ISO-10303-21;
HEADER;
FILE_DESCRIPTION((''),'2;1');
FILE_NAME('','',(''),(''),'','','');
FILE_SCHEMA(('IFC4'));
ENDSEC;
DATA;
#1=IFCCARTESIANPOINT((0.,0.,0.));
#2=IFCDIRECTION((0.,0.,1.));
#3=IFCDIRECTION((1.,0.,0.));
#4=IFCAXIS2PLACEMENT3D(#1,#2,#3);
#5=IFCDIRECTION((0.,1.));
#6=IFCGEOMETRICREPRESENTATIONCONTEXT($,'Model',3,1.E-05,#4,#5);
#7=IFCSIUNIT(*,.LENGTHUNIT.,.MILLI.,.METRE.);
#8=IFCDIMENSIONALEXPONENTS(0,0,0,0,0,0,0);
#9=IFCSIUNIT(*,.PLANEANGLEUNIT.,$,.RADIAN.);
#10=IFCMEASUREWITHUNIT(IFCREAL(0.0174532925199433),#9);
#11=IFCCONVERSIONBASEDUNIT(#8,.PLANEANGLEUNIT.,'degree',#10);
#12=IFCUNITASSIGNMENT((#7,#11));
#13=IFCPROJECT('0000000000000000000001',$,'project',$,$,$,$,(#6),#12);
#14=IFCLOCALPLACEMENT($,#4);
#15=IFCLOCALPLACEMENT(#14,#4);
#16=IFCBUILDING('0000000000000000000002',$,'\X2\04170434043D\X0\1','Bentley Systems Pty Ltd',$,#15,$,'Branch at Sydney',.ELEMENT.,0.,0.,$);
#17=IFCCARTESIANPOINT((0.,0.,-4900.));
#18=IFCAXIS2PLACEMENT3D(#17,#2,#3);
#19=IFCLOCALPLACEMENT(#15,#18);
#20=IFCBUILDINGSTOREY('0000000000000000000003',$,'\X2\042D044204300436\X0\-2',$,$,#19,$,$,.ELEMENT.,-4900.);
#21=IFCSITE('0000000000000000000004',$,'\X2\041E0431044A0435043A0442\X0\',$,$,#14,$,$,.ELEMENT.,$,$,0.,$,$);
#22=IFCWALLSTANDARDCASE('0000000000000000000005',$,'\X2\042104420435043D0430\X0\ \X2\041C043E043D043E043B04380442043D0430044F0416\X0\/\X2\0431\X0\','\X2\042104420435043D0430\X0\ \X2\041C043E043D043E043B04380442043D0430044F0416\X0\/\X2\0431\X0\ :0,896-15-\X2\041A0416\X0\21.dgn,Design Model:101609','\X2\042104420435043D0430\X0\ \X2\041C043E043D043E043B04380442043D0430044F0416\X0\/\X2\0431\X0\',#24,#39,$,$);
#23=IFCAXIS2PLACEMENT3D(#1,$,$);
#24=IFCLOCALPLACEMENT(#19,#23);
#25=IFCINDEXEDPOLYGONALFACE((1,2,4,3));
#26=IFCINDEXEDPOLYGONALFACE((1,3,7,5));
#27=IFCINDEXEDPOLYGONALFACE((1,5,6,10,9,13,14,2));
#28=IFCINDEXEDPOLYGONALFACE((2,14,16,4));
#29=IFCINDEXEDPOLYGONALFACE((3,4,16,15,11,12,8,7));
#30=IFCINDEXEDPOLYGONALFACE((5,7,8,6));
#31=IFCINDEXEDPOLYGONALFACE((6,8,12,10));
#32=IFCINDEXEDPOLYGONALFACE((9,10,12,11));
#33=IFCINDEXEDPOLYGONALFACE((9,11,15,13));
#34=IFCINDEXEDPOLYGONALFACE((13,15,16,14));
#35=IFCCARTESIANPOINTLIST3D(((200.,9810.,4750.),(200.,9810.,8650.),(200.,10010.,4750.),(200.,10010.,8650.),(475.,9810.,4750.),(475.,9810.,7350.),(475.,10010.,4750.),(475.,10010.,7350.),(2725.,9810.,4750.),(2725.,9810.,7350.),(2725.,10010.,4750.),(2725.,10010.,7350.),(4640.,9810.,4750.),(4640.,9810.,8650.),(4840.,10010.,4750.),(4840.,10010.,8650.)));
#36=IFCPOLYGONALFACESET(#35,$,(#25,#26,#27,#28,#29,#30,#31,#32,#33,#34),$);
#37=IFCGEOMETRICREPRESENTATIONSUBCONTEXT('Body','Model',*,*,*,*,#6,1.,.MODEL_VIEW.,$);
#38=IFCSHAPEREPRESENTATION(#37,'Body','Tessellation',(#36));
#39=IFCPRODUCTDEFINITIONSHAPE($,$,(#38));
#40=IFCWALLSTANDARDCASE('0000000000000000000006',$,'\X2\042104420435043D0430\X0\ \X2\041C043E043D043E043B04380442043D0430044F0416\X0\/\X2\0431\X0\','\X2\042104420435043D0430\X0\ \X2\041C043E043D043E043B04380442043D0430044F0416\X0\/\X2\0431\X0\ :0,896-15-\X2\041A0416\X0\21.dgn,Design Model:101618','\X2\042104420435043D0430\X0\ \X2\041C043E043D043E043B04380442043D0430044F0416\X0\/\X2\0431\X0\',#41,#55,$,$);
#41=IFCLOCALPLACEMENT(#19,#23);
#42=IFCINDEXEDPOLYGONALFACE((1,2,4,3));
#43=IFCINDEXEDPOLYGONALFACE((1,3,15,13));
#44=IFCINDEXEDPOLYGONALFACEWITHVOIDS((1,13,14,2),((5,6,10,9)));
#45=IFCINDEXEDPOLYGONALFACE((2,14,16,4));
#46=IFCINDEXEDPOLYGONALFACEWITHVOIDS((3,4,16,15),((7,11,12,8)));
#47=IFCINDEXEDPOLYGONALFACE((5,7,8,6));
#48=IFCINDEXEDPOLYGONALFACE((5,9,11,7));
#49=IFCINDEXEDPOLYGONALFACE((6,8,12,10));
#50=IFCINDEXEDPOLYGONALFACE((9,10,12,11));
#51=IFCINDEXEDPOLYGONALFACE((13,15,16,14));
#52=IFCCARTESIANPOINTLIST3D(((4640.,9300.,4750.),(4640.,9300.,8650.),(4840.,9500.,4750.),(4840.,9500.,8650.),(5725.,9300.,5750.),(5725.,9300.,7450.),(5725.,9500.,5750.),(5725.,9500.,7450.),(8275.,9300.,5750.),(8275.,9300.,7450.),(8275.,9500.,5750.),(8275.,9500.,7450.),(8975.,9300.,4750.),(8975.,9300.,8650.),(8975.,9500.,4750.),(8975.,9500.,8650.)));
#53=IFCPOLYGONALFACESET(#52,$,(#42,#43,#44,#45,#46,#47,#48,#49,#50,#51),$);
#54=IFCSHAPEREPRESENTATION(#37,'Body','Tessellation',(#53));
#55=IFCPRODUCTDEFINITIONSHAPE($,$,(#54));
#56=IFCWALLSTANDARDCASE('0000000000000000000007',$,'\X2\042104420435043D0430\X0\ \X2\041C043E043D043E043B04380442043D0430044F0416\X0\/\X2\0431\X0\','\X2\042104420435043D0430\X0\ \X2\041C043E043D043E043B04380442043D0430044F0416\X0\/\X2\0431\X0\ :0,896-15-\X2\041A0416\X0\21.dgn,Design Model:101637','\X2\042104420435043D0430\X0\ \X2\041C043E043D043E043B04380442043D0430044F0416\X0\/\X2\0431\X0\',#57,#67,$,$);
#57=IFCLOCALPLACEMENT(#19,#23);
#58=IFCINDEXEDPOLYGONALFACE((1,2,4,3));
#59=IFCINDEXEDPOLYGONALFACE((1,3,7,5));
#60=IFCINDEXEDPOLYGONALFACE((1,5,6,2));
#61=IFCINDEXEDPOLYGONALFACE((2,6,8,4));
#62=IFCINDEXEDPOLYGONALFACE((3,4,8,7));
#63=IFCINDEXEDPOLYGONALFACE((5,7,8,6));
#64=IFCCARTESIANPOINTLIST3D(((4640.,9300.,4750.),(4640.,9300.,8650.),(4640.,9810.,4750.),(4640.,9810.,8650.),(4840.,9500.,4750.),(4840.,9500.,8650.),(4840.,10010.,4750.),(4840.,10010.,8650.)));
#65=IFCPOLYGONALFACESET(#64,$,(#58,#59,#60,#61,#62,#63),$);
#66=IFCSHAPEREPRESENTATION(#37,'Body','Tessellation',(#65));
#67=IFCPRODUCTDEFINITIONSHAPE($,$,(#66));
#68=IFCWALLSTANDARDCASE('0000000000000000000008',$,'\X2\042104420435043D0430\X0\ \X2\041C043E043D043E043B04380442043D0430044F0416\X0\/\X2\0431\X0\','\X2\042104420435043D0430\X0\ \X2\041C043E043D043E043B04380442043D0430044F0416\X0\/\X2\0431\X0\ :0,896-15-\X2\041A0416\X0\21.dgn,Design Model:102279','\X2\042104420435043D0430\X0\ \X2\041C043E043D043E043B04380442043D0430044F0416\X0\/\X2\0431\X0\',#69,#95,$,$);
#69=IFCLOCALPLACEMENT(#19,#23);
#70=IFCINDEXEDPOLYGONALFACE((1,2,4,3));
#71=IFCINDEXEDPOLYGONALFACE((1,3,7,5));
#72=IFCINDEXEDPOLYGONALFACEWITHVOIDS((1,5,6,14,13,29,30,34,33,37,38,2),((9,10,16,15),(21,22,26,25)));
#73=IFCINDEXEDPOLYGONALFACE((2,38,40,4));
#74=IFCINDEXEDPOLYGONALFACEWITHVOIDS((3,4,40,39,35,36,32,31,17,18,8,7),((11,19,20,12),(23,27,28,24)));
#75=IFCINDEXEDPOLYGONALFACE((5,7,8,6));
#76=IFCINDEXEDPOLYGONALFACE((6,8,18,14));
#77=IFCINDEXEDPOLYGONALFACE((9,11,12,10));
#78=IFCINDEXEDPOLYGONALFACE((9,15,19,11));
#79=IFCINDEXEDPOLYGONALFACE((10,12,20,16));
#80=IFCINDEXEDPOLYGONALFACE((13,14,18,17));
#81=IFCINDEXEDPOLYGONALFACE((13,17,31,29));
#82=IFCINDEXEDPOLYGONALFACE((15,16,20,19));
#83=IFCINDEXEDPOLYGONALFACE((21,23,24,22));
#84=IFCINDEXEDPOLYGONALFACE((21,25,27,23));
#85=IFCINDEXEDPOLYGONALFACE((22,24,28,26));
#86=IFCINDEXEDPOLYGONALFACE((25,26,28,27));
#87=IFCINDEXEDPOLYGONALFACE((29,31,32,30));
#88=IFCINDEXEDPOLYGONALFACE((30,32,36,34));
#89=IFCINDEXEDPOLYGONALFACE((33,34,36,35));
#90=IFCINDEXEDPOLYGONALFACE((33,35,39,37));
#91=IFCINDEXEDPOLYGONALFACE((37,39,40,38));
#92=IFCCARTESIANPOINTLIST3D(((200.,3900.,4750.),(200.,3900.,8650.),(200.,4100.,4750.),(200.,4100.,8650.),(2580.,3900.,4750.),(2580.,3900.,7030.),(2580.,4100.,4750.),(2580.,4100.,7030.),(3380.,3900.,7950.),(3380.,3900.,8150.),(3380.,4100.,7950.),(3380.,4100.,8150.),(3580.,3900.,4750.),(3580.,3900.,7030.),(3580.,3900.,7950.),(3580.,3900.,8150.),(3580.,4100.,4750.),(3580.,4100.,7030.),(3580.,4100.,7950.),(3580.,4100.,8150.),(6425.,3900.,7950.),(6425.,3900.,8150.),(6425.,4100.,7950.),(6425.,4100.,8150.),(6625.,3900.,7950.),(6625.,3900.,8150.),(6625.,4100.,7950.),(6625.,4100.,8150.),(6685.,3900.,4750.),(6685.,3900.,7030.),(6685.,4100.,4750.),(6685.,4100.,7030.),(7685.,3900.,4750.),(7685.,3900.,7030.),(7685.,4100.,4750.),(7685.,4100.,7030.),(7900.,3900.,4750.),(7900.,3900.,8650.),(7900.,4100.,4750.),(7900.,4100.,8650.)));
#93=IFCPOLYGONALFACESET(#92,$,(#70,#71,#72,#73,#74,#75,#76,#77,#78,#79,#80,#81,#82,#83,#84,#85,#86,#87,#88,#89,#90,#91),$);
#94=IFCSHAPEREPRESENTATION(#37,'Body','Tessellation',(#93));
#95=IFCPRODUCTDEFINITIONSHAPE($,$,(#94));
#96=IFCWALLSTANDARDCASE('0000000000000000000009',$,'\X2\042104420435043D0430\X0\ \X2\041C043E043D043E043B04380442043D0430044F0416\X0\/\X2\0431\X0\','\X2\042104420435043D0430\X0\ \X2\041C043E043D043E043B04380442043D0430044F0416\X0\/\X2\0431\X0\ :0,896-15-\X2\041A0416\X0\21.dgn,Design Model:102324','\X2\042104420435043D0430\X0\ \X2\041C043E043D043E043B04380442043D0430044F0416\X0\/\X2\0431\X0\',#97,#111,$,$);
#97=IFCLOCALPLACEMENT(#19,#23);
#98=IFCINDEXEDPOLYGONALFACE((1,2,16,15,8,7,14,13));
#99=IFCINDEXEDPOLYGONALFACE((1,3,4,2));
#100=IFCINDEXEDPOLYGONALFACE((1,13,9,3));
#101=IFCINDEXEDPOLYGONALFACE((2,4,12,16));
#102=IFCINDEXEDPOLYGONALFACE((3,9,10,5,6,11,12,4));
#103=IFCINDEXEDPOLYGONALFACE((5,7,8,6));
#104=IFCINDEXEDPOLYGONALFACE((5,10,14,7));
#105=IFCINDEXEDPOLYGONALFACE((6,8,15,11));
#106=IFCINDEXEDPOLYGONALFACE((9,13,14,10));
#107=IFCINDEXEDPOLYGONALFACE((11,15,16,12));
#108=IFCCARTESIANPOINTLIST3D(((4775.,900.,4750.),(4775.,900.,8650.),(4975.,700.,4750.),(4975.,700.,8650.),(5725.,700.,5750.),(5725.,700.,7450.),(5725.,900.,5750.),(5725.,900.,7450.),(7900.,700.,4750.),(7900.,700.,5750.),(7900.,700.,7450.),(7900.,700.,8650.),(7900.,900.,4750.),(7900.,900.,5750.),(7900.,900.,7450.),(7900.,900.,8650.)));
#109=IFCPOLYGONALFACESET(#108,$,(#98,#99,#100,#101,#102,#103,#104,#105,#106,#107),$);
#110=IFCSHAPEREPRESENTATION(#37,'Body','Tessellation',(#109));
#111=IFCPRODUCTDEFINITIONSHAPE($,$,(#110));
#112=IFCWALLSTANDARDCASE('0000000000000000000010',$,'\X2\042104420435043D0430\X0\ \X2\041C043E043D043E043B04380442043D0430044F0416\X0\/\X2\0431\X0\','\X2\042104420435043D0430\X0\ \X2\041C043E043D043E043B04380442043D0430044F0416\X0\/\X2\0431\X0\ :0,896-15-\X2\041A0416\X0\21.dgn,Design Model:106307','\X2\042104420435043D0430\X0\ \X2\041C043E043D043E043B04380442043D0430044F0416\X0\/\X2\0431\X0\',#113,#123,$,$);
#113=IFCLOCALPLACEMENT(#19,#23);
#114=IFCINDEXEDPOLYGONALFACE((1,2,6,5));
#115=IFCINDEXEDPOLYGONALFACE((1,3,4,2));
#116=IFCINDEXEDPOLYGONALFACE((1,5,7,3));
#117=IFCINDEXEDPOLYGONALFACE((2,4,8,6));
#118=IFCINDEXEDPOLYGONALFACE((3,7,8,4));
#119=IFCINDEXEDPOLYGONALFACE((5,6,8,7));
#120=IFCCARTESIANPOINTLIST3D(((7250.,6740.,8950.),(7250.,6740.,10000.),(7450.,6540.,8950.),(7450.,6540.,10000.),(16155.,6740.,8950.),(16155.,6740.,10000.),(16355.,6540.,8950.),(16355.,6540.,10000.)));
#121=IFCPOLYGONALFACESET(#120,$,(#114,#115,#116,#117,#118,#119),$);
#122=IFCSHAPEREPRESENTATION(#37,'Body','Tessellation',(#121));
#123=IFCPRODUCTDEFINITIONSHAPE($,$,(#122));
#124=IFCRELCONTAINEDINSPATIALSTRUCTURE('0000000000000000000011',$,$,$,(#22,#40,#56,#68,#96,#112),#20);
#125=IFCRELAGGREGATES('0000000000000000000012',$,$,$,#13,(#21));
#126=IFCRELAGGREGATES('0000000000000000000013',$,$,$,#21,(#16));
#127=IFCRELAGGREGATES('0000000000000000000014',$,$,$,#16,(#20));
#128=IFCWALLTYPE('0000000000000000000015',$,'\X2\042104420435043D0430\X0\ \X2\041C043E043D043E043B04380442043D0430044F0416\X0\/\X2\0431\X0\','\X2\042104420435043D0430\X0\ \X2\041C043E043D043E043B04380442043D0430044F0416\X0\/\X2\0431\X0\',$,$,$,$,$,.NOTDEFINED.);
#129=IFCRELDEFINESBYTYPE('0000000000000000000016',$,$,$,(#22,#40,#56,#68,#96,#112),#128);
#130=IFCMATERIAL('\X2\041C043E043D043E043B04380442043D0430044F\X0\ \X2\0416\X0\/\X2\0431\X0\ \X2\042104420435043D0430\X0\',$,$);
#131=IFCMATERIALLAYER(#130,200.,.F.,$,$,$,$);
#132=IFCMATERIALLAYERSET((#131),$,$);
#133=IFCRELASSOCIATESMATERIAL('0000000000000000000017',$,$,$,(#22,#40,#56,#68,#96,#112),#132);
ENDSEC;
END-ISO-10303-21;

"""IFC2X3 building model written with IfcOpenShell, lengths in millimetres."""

from ifc_helpers import new_model, entity, si_unit, converted_unit, direction, frame, frame_2d, origin_with_axes, place, context, subcontext, project, spatial, polyline, rectangle, outline, extrude, material, layer, layer_set, layer_usage, type_object, element, save


model = new_model("IFC2X3")

# Units and contexts
model_context = context("Model", 3, precision=1e-05, world=origin_with_axes(), true_north=direction((0.0, 1.0)))
body_context = subcontext(model_context, "Body", "Model", "MODEL_VIEW", scale=1.0)
ifc_project = project(units=[si_unit("LENGTHUNIT", "METRE", prefix="MILLI"), converted_unit("PLANEANGLEUNIT", "degree", entity("IfcReal", 0.0174532925199433), si_unit("PLANEANGLEUNIT", "RADIAN"), dimensions=[0, 0, 0, 0, 0, 0, 0])], contexts=[model_context])

# Site, building, storey
site_placement = place(None, origin_with_axes())
site = spatial("IfcSite", under=ifc_project, at=site_placement, Name="Объект", CompositionType="ELEMENT", RefElevation=0.0)
building_placement = place(site_placement, origin_with_axes())
building = spatial("IfcBuilding", under=site, at=building_placement, Name="Здн1", Description="Bentley Systems Pty Ltd", LongName="Branch at Sydney", CompositionType="ELEMENT", ElevationOfRefHeight=0.0, ElevationOfTerrain=0.0)
storey_placement = place(building_placement, frame((0.0, 0.0, -4900.0), z_axis=(0.0, 0.0, 1.0), x_axis=(1.0, 0.0, 0.0)))
storey = spatial("IfcBuildingStorey", under=building, at=storey_placement, Name="Этаж-2", CompositionType="ELEMENT", Elevation=-4900.0)

# Shared definitions
ifc_material = material(Name="Монолитная Ж/б Стена")
wall_type = type_object("IfcWallType", Name="Стена МонолитнаяЖ/б", Description="Стена МонолитнаяЖ/б", PredefinedType="NOTDEFINED")

# Shared definitions
ifc_layer_1 = layer(ifc_material, 200.0, ventilated=False)
ifc_layer_set_1 = layer_set([ifc_layer_1])
ifc_layer_usage_1 = layer_usage(ifc_layer_set_1, "AXIS2", "POSITIVE", 0.0)

# Walls, openings
wall_1_placement = place(storey_placement, frame((200.0, 10010.0, 4750.0), z_axis=(0.0, 0.0, 1.0), x_axis=(1.0, 0.0, 0.0)))
wall_1 = element("IfcWallStandardCase", 1, at=wall_1_placement, inside=storey, type_object=wall_type, material=ifc_layer_usage_1, Name="Стена МонолитнаяЖ/б", Description="Стена МонолитнаяЖ/б :0,896-15-КЖ21.dgn,Design Model:101609", ObjectType="Стена МонолитнаяЖ/б", context=body_context, shape_type="SweptSolid", body=[
    extrude(outline(polyline([(4640.0, 0.0), (0.0, 0.0), (0.0, -200.0), (4440.0, -200.0), (4640.0, 0.0)])), origin_with_axes(), (0.0, 0.0, 1.0), 3900.0),
])
opening_1_placement = place(wall_1_placement, frame((275.0, -200.0, 0.0), z_axis=(0.0, 0.0, 1.0), x_axis=(1.0, 0.0, 0.0)))
element("IfcOpeningElement", 2, at=opening_1_placement, cuts=wall_1, ObjectType="Opening", context=body_context, shape_type="SweptSolid", body=[
    extrude(rectangle(XDim=2600.0, YDim=2250.0, at=frame_2d((-1125.0, 1300.0), x_axis=(0.0, -1.0))), frame((0.0, 0.0, 0.0), z_axis=(0.0, 1.0, 0.0), x_axis=(-1.0, 0.0, 0.0)), (0.0, 0.0, 1.0), 200.0),
])
wall_2_placement = place(storey_placement, frame((4640.0, 9300.0, 4750.0), z_axis=(0.0, 0.0, 1.0), x_axis=(1.0, 0.0, 0.0)))
wall_2 = element("IfcWallStandardCase", 3, at=wall_2_placement, inside=storey, type_object=wall_type, material=ifc_layer_usage_1, Name="Стена МонолитнаяЖ/б", Description="Стена МонолитнаяЖ/б :0,896-15-КЖ21.dgn,Design Model:101618", ObjectType="Стена МонолитнаяЖ/б", context=body_context, shape_type="SweptSolid", body=[
    extrude(outline(polyline([(200.0, 200.0), (0.0, 0.0), (4335.0, 0.0), (4335.0, 200.0), (200.0, 200.0)])), origin_with_axes(), (0.0, 0.0, 1.0), 3900.0),
])
opening_2_placement = place(wall_2_placement, frame((1085.0, 0.0, 1000.0), z_axis=(0.0, 0.0, 1.0), x_axis=(1.0, 0.0, 0.0)))
element("IfcOpeningElement", 4, at=opening_2_placement, cuts=wall_2, ObjectType="Opening", context=body_context, shape_type="SweptSolid", body=[
    extrude(rectangle(XDim=1700.0, YDim=2550.0, at=frame_2d((-1275.0, 850.0), x_axis=(0.0, -1.0))), frame((0.0, 0.0, 0.0), z_axis=(0.0, 1.0, 0.0), x_axis=(-1.0, 0.0, 0.0)), (0.0, 0.0, 1.0), 200.0),
])

# Wall
wall_3_placement = place(storey_placement, frame((4840.0, 10010.0, 4750.0), z_axis=(0.0, 0.0, 1.0), x_axis=(0.0, -1.0, 0.0)))
element("IfcWallStandardCase", 5, at=wall_3_placement, inside=storey, type_object=wall_type, material=ifc_layer_usage_1, Name="Стена МонолитнаяЖ/б", Description="Стена МонолитнаяЖ/б :0,896-15-КЖ21.dgn,Design Model:101637", ObjectType="Стена МонолитнаяЖ/б", context=body_context, shape_type="SweptSolid", body=[
    extrude(outline(polyline([(510.0, 0.0), (0.0, 0.0), (200.0, -200.0), (710.0, -200.0), (510.0, 0.0)])), origin_with_axes(), (0.0, 0.0, 1.0), 3900.0),
])

# Wall, openings
wall_4_placement = place(storey_placement, frame((200.0, 3900.0, 4750.0), z_axis=(0.0, 0.0, 1.0), x_axis=(1.0, 0.0, 0.0)))
wall_4 = element("IfcWallStandardCase", 6, at=wall_4_placement, inside=storey, type_object=wall_type, material=ifc_layer_usage_1, Name="Стена МонолитнаяЖ/б", Description="Стена МонолитнаяЖ/б :0,896-15-КЖ21.dgn,Design Model:102279", ObjectType="Стена МонолитнаяЖ/б", context=body_context, shape_type="SweptSolid", body=[
    extrude(rectangle(XDim=7700.0, YDim=200.0, at=frame_2d((3850.0, 100.0), x_axis=(1.0, 0.0))), origin_with_axes(), (0.0, 0.0, 1.0), 3900.0),
])
opening_3_placement = place(wall_4_placement, frame((2380.0, 0.0, 0.0), z_axis=(0.0, 0.0, 1.0), x_axis=(1.0, 0.0, 0.0)))
element("IfcOpeningElement", 7, at=opening_3_placement, cuts=wall_4, ObjectType="Opening", context=body_context, shape_type="SweptSolid", body=[
    extrude(rectangle(XDim=2280.0, YDim=1000.0, at=frame_2d((-500.0, 1140.0), x_axis=(0.0, -1.0))), frame((0.0, 0.0, 0.0), z_axis=(0.0, 1.0, 0.0), x_axis=(-1.0, 0.0, 0.0)), (0.0, 0.0, 1.0), 200.0),
])
opening_4_placement = place(wall_4_placement, frame((6485.0, 0.0, 0.0), z_axis=(0.0, 0.0, 1.0), x_axis=(1.0, 0.0, 0.0)))
element("IfcOpeningElement", 8, at=opening_4_placement, cuts=wall_4, ObjectType="Opening", context=body_context, shape_type="SweptSolid", body=[
    extrude(rectangle(XDim=2280.0, YDim=1000.0, at=frame_2d((-500.0, 1140.0), x_axis=(0.0, -1.0))), frame((0.0, 0.0, 0.0), z_axis=(0.0, 1.0, 0.0), x_axis=(-1.0, 0.0, 0.0)), (0.0, 0.0, 1.0), 200.0),
])
opening_5_placement = place(wall_4_placement, frame((3180.0, 0.0, 3200.0), z_axis=(0.0, 0.0, 1.0), x_axis=(1.0, 0.0, 0.0)))
element("IfcOpeningElement", 9, at=opening_5_placement, cuts=wall_4, ObjectType="Opening", context=body_context, shape_type="SweptSolid", body=[
    extrude(rectangle(XDim=200.0, YDim=200.0, at=frame_2d((-100.0, 100.0), x_axis=(0.0, -1.0))), frame((0.0, 0.0, 0.0), z_axis=(0.0, 1.0, 0.0), x_axis=(-1.0, 0.0, 0.0)), (0.0, 0.0, 1.0), 200.0),
])
opening_6_placement = place(wall_4_placement, frame((6225.0, 0.0, 3200.0), z_axis=(0.0, 0.0, 1.0), x_axis=(1.0, 0.0, 0.0)))
element("IfcOpeningElement", 10, at=opening_6_placement, cuts=wall_4, ObjectType="Opening", context=body_context, shape_type="SweptSolid", body=[
    extrude(rectangle(XDim=200.0, YDim=200.0, at=frame_2d((-100.0, 100.0), x_axis=(0.0, -1.0))), frame((0.0, 0.0, 0.0), z_axis=(0.0, 1.0, 0.0), x_axis=(-1.0, 0.0, 0.0)), (0.0, 0.0, 1.0), 200.0),
])

# Wall, opening
wall_5_placement = place(storey_placement, frame((7900.0, 700.0, 4750.0), z_axis=(0.0, 0.0, 1.0), x_axis=(-1.0, 0.000002, 0.0)))
wall_5 = element("IfcWallStandardCase", 11, at=wall_5_placement, inside=storey, type_object=wall_type, material=ifc_layer_usage_1, Name="Стена МонолитнаяЖ/б", Description="Стена МонолитнаяЖ/б :0,896-15-КЖ21.dgn,Design Model:102324", ObjectType="Стена МонолитнаяЖ/б", context=body_context, shape_type="SweptSolid", body=[
    extrude(outline(polyline([(2925.0, 0.0), (0.0, 0.0), (0.0, -200.0), (3125.0, -200.0), (2925.0, 0.0)])), origin_with_axes(), (0.0, 0.0, 1.0), 3900.0),
])
opening_7_placement = place(wall_5_placement, frame((-375.0, -200.0, 1000.0), z_axis=(0.0, 0.0, 1.0), x_axis=(1.0, 0.0, 0.0)))
element("IfcOpeningElement", 12, at=opening_7_placement, cuts=wall_5, ObjectType="Opening", context=body_context, shape_type="SweptSolid", body=[
    extrude(rectangle(XDim=1700.0, YDim=2550.0, at=frame_2d((-1275.0, 850.0), x_axis=(0.0, -1.0))), frame((0.0, 0.0, 0.0), z_axis=(0.0, 1.0, 0.0), x_axis=(-1.0, 0.0, 0.0)), (0.0, 0.0, 1.0), 200.0),
])

# Wall
wall_6_placement = place(storey_placement, frame((7250.0, 6740.0, 8950.0), z_axis=(0.0, 0.0, 1.0), x_axis=(1.0, 0.0, 0.0)))
element("IfcWallStandardCase", 13, at=wall_6_placement, inside=storey, type_object=wall_type, material=ifc_layer_usage_1, Name="Стена МонолитнаяЖ/б", Description="Стена МонолитнаяЖ/б :0,896-15-КЖ21.dgn,Design Model:106307", ObjectType="Стена МонолитнаяЖ/б", context=body_context, shape_type="SweptSolid", body=[
    extrude(outline(polyline([(8905.0, 0.0), (0.0, 0.0), (200.0, -200.0), (9105.0, -200.0), (8905.0, 0.0)])), origin_with_axes(), (0.0, 0.0, 1.0), 1050.0),
])

save(model, "model.ifc")
